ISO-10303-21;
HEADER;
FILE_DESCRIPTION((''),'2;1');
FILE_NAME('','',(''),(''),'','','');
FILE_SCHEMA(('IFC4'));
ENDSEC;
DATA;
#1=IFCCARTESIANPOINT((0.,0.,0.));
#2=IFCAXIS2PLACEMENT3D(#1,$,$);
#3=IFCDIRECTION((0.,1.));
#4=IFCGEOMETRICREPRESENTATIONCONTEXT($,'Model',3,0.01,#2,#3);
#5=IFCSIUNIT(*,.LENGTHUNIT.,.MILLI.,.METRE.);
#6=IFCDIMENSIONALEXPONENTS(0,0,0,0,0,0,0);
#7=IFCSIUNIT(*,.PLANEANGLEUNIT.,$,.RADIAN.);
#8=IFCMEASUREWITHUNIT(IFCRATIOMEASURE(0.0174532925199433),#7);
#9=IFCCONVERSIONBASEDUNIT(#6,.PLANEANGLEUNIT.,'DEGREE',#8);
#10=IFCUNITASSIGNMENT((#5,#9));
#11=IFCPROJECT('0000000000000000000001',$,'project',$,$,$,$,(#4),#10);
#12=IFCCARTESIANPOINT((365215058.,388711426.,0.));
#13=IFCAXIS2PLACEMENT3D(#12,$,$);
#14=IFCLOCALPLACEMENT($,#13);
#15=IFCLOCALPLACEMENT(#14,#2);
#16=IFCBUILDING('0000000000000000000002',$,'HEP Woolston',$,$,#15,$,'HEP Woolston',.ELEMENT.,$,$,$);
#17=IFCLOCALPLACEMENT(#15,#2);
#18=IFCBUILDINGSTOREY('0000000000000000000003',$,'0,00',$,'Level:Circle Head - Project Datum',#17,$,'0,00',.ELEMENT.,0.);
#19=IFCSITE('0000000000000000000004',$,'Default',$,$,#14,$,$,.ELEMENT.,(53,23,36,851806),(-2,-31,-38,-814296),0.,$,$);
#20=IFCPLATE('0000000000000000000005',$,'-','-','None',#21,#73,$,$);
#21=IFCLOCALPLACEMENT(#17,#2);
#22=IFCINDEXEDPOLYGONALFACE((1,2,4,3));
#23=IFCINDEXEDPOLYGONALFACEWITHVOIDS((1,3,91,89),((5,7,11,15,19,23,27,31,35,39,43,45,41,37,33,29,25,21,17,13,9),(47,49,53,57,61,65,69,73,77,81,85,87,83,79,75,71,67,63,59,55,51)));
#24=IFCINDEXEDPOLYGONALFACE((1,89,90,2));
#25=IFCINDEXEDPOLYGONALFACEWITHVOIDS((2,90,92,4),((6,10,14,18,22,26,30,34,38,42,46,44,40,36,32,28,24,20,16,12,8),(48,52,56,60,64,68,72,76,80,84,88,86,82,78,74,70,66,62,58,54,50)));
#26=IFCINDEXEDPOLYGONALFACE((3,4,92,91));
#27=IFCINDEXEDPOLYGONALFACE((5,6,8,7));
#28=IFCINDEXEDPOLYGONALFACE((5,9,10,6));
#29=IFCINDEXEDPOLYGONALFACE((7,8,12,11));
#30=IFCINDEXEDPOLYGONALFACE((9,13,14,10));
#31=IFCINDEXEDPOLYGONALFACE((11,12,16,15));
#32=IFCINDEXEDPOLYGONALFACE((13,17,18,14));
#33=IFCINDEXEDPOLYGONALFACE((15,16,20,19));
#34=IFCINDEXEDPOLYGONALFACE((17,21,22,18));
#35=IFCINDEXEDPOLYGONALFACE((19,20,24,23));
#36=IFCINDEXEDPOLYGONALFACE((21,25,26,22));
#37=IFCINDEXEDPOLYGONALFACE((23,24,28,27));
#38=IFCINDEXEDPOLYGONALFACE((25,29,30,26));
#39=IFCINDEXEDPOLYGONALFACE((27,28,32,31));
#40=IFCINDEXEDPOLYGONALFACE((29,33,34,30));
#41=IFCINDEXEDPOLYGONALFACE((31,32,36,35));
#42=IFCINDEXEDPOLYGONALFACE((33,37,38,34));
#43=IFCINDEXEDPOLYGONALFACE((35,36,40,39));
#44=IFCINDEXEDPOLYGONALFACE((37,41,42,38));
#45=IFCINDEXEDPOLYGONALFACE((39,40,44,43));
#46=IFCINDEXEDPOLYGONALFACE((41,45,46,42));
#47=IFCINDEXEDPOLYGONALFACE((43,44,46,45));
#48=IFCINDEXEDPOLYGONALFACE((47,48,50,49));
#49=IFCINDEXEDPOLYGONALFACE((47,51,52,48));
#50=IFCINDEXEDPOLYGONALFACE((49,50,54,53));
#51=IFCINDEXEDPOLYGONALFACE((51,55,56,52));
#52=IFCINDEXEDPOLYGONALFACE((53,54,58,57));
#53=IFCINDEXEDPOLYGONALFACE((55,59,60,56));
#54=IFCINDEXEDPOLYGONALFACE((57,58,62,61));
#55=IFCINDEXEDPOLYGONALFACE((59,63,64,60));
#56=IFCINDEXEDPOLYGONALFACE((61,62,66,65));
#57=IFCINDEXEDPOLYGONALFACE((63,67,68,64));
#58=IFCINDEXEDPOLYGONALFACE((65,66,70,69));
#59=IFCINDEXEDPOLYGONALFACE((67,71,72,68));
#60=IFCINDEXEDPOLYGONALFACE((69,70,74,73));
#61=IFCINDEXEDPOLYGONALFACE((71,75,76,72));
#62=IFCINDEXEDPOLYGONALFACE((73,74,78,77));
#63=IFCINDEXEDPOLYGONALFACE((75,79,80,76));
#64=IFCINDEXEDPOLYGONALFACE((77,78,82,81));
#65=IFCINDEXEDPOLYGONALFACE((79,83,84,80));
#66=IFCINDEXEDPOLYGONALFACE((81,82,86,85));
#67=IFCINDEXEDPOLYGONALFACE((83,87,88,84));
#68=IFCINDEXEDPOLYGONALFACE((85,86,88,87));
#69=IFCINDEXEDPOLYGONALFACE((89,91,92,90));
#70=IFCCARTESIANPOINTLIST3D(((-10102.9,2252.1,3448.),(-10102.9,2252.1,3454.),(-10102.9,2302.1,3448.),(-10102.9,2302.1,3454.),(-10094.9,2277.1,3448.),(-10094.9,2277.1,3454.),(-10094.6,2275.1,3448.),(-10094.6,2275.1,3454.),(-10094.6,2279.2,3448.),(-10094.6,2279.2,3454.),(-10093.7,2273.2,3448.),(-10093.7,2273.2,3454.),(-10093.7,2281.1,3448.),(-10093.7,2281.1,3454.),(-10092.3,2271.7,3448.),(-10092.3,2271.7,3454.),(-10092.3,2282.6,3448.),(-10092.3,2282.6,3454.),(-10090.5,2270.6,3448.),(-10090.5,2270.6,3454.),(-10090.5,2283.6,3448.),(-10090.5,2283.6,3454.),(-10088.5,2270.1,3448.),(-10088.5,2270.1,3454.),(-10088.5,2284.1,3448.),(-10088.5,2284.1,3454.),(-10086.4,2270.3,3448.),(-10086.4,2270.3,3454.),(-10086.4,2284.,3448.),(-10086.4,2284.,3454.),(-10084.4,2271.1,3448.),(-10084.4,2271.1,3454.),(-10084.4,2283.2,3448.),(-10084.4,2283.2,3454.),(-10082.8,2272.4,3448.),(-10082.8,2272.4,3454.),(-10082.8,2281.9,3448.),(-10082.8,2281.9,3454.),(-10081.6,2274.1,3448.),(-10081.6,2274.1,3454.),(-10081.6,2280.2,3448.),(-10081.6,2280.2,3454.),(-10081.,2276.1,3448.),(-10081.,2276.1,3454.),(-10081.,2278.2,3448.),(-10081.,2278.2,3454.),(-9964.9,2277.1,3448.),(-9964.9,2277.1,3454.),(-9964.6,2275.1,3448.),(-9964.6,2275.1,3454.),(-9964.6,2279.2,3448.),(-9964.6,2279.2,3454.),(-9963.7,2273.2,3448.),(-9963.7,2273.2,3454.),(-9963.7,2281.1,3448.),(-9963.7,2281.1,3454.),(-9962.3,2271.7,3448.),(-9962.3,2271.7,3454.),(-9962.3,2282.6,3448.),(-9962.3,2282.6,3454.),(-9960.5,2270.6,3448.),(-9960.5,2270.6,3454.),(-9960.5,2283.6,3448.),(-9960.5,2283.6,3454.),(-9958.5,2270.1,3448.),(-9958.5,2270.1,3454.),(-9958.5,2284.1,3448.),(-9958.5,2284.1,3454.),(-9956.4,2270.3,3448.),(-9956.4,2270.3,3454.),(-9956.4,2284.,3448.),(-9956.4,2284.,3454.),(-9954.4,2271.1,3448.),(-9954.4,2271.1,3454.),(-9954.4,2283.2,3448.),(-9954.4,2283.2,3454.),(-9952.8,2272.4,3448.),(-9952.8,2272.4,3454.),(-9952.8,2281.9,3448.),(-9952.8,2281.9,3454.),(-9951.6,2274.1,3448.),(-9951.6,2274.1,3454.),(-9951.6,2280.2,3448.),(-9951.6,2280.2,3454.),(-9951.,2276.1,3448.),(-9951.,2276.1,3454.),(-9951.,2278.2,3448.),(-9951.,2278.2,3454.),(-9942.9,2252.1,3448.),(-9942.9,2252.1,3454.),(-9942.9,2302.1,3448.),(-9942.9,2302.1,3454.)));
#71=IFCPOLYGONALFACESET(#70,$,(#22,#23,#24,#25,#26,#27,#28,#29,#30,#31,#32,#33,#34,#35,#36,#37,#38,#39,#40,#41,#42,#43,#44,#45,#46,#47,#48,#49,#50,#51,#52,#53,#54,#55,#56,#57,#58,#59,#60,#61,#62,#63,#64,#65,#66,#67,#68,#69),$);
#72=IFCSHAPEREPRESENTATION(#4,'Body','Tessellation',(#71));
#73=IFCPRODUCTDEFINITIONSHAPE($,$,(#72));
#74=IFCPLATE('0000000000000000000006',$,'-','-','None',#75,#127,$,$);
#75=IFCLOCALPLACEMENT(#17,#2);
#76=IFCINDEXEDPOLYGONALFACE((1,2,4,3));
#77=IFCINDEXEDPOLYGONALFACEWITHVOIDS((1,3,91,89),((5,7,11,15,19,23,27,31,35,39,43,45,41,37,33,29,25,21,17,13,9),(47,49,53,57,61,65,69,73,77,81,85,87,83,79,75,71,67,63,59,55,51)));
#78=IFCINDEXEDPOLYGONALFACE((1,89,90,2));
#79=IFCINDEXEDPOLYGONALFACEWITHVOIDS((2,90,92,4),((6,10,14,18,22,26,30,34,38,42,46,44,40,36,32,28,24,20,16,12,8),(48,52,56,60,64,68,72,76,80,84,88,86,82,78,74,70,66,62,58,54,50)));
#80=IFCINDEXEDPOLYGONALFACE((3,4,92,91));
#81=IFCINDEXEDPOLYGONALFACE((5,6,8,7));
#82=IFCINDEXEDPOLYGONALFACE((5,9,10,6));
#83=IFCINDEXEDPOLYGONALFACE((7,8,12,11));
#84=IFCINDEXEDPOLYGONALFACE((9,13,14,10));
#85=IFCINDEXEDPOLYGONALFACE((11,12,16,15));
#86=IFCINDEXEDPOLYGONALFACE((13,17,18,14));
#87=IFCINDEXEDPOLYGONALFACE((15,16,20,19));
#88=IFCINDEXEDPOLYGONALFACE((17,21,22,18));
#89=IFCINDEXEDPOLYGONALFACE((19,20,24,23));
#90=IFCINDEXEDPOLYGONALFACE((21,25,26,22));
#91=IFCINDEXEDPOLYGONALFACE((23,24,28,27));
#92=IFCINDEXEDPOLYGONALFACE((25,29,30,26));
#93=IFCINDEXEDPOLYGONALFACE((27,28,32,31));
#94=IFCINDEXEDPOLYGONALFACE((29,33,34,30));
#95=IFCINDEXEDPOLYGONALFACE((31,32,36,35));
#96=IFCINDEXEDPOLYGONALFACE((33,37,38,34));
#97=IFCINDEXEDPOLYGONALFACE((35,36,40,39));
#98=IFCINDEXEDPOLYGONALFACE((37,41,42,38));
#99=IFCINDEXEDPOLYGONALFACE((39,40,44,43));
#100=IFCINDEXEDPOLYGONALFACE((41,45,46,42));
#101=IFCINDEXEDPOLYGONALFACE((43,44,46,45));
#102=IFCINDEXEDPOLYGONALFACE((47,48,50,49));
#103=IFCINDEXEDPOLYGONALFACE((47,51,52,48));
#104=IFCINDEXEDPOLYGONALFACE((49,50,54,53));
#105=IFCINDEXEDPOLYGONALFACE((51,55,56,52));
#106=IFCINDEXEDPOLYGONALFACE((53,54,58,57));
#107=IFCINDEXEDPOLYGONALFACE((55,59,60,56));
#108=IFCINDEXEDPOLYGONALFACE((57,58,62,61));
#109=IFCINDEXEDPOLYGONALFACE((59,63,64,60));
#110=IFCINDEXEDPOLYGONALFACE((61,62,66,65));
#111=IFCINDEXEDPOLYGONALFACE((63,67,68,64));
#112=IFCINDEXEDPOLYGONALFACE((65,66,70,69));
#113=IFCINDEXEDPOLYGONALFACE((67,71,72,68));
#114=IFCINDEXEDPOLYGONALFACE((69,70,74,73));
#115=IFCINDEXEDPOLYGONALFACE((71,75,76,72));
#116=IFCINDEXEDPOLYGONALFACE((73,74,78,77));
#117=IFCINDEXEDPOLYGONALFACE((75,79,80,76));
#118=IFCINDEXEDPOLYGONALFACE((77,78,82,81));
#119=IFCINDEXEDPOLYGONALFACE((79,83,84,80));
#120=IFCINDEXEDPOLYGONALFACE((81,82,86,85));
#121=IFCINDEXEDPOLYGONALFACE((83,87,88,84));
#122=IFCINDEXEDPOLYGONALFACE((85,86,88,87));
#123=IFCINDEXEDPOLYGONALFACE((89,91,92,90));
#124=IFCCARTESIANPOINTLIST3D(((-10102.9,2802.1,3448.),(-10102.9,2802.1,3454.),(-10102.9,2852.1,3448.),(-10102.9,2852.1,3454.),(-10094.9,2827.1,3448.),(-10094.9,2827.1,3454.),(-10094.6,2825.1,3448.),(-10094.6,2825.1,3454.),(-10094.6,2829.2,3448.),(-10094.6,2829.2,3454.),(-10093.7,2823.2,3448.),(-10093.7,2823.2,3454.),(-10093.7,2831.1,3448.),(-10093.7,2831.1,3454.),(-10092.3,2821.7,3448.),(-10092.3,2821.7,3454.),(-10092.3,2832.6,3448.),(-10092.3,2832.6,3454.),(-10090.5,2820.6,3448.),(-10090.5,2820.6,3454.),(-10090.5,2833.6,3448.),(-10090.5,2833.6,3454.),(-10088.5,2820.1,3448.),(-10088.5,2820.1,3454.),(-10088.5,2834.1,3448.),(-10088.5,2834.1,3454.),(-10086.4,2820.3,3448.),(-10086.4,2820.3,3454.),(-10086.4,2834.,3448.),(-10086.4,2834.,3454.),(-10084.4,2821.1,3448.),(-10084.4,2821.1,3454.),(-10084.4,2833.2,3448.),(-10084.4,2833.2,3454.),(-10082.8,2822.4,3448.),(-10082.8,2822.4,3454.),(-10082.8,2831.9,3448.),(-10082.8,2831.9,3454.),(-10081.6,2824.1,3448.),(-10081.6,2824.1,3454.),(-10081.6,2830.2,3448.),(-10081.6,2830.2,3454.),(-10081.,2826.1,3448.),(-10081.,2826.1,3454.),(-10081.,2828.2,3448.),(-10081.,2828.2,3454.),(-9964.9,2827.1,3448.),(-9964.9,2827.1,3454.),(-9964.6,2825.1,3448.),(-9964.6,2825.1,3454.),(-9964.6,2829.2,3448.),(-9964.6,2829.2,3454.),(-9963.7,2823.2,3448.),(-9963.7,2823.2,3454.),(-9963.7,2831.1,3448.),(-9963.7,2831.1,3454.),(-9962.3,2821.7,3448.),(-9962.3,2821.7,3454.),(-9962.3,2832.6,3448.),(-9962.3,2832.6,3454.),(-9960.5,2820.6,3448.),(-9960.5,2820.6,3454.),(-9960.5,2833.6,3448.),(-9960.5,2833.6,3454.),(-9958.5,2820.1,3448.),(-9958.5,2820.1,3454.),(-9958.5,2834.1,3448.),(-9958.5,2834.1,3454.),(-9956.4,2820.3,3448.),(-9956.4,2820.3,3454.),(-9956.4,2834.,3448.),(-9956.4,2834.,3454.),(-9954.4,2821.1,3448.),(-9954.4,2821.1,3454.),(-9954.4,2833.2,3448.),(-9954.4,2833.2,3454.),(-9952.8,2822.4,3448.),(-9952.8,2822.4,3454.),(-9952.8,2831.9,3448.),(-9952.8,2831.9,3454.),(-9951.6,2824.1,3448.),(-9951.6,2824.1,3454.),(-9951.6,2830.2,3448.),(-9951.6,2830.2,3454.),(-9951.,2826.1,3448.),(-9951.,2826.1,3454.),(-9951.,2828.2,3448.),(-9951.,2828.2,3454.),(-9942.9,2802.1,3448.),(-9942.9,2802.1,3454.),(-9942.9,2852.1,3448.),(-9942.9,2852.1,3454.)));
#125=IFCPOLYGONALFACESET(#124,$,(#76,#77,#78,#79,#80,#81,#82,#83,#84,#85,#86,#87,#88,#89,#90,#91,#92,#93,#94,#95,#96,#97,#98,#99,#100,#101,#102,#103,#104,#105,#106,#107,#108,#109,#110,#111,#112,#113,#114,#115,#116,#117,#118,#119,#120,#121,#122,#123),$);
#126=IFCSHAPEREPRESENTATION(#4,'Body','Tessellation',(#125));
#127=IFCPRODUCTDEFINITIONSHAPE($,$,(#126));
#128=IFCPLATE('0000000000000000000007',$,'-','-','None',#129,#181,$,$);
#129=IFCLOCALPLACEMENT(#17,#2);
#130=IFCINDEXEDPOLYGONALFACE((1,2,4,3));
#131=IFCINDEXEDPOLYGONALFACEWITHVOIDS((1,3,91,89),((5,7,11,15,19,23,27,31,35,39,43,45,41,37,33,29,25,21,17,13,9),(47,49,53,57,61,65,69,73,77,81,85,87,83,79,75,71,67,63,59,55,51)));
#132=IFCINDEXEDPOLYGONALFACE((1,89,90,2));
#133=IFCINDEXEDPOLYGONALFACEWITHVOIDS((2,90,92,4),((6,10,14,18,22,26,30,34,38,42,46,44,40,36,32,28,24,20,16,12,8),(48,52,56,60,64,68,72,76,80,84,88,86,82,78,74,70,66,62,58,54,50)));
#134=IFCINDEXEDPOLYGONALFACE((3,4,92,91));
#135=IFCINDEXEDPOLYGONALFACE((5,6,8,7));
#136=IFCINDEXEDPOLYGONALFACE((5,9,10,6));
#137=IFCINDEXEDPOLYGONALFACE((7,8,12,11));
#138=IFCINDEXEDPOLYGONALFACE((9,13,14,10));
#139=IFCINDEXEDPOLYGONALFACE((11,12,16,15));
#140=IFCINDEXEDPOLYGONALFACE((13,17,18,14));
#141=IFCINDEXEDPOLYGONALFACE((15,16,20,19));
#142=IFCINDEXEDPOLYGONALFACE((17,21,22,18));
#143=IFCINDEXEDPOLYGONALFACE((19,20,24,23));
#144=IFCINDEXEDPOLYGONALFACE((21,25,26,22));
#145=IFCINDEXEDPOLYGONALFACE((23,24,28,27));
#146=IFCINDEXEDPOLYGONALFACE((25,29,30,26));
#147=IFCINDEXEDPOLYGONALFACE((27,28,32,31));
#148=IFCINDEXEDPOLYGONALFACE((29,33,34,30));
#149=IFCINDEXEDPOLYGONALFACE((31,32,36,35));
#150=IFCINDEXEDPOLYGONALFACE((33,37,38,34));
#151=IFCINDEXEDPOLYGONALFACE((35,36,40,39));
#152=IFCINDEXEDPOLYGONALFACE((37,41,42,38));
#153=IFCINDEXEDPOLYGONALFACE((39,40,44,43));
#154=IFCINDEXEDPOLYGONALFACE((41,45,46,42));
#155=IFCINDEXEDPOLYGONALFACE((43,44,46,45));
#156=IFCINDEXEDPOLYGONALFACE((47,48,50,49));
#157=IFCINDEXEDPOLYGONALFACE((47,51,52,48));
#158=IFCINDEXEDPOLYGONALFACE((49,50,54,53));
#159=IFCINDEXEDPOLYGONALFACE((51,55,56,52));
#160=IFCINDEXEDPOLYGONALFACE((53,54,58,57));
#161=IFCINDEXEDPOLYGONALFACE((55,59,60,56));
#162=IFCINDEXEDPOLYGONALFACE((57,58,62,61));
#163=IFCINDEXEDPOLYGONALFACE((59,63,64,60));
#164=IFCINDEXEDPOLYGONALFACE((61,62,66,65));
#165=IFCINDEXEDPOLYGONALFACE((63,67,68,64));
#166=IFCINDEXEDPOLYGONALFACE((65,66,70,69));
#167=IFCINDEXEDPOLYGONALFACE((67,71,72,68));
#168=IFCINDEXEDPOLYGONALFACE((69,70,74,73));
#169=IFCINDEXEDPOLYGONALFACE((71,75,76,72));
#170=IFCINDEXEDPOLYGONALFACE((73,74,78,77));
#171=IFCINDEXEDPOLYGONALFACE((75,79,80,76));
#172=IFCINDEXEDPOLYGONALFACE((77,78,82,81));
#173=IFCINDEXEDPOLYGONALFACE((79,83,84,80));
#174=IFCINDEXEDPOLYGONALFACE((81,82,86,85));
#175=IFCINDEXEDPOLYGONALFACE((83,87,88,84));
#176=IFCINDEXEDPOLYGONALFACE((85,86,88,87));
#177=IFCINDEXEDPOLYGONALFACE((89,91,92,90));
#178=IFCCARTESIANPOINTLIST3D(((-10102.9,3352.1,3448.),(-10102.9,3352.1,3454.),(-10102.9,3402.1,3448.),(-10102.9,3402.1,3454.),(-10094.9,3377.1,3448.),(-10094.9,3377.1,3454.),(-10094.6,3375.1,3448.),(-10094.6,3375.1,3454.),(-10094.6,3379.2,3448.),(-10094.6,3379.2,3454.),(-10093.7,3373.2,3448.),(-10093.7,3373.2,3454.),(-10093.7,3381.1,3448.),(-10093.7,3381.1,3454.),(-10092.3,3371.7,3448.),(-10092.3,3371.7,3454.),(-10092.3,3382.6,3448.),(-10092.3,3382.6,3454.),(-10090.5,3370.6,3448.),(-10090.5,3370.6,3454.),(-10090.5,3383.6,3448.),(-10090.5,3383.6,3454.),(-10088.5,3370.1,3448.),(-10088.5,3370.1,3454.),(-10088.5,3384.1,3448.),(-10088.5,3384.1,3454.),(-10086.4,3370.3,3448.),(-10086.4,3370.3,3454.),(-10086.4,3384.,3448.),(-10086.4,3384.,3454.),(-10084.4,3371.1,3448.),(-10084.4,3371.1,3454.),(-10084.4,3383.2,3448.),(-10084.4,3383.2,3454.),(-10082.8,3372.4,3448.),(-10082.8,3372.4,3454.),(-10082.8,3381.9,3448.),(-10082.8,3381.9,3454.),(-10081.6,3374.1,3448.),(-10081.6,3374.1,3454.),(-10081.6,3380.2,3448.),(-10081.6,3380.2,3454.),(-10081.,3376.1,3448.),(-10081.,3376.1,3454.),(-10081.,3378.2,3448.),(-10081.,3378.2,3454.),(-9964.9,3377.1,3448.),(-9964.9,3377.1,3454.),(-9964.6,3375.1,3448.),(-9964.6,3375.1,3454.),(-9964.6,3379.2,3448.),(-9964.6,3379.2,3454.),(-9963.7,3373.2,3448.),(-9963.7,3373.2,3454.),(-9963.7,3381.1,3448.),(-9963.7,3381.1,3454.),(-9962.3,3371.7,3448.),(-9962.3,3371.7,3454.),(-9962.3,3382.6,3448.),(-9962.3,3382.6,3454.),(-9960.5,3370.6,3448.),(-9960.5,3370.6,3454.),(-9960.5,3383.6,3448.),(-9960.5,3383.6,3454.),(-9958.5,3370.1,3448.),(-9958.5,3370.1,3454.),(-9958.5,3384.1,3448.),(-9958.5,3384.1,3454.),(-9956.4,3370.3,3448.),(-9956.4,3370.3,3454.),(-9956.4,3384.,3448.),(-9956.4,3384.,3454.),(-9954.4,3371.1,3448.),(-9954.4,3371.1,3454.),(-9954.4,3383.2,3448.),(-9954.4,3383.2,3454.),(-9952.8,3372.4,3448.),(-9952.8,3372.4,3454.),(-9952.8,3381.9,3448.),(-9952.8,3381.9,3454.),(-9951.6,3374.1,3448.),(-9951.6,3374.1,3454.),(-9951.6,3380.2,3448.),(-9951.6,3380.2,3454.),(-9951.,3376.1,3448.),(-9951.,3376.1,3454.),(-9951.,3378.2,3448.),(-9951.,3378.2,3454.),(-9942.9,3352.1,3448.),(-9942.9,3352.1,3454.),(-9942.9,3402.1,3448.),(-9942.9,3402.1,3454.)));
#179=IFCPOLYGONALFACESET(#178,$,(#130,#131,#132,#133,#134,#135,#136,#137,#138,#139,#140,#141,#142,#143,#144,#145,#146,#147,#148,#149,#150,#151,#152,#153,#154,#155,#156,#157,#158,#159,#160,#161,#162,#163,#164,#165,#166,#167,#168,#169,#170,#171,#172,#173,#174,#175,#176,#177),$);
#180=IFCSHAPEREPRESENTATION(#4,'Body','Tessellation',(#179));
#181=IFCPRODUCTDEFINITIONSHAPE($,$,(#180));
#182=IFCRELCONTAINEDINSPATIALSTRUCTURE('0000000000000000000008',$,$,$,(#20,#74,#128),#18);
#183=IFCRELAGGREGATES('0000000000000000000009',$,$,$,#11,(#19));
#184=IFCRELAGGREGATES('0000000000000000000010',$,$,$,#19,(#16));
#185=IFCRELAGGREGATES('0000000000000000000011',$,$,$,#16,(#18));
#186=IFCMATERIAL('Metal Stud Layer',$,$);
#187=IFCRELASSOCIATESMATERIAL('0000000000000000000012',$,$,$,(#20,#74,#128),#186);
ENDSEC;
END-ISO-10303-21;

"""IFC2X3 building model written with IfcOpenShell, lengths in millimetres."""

from ifc_helpers import new_model, entity, si_unit, converted_unit, direction, frame, frame_2d, origin, origin_with_axes, place, context, project, spatial, polyline, circle, outline, extrude, material, element, save


model = new_model("IFC2X3")

# Units and contexts
model_context = context("Model", 3, precision=0.01, world=origin(), true_north=direction((0.0, 1.0)))
ifc_project = project(units=[si_unit("LENGTHUNIT", "METRE", prefix="MILLI"), converted_unit("PLANEANGLEUNIT", "DEGREE", entity("IfcRatioMeasure", 0.0174532925199433), si_unit("PLANEANGLEUNIT", "RADIAN"), dimensions=[0, 0, 0, 0, 0, 0, 0])], contexts=[model_context])

# Site, building, storey
site_placement = place(None, frame((365215058.0, 388711426.0, 0.0)))
site = spatial("IfcSite", under=ifc_project, at=site_placement, Name="Default", CompositionType="ELEMENT", RefLatitude=(53, 23, 36, 851806), RefLongitude=(-2, -31, -38, -814296), RefElevation=0.0)
building_placement = place(site_placement, origin())
building = spatial("IfcBuilding", under=site, at=building_placement, Name="HEP Woolston", LongName="HEP Woolston", CompositionType="ELEMENT")
storey_placement = place(building_placement, origin())
storey = spatial("IfcBuildingStorey", under=building, at=storey_placement, Name="0,00", ObjectType="Level:Circle Head - Project Datum", LongName="0,00", CompositionType="ELEMENT", Elevation=0.0)

# Plates, openings
ifc_material = material(Name="Metal Stud Layer")
plate_1_placement = place(storey_placement, frame((-9942.9, 2252.1, 3454.0), z_axis=(0.0, 0.0, -1.0), x_axis=(-1.0, 0.0, 0.0)))
plate_1 = element("IfcPlate", 1, at=plate_1_placement, inside=storey, material=ifc_material, Name="-", Description="-", ObjectType="None", context=model_context, shape_type="SweptSolid", body=[
    extrude(outline(polyline([(160.0, 0.0), (160.0, 50.0), (0.0, 50.0), (0.0, 0.0), (160.0, 0.0)])), origin_with_axes(), (0.0, 0.0, 1.0), 6.0),
])
opening_1_placement = place(plate_1_placement, frame((80.0, 25.0, 6.5), z_axis=(0.0, 0.0, -1.0), x_axis=(1.0, 0.0, 0.0)))
element("IfcOpeningElement", 2, at=opening_1_placement, cuts=plate_1, ObjectType="Opening", context=model_context, shape_type="SweptSolid", body=[
    extrude(circle(Radius=7.0, at=frame_2d((65.0, 0.0), x_axis=(1.0, 0.0))), origin(), (0.0, 0.0, 1.0), 7.0),
])
opening_2_placement = place(plate_1_placement, frame((80.0, 25.0, 6.5), z_axis=(0.0, 0.0, -1.0), x_axis=(1.0, 0.0, 0.0)))
element("IfcOpeningElement", 3, at=opening_2_placement, cuts=plate_1, ObjectType="Opening", context=model_context, shape_type="SweptSolid", body=[
    extrude(circle(Radius=7.0, at=frame_2d((-65.0, 0.0), x_axis=(1.0, 0.0))), origin(), (0.0, 0.0, 1.0), 7.0),
])
plate_2_placement = place(storey_placement, frame((-9942.9, 2802.1, 3454.0), z_axis=(0.0, 0.0, -1.0), x_axis=(-1.0, 0.0, 0.0)))
plate_2 = element("IfcPlate", 4, at=plate_2_placement, inside=storey, material=ifc_material, Name="-", Description="-", ObjectType="None", context=model_context, shape_type="SweptSolid", body=[
    extrude(outline(polyline([(160.0, 0.0), (160.0, 50.0), (0.0, 50.0), (0.0, 0.0), (160.0, 0.0)])), origin_with_axes(), (0.0, 0.0, 1.0), 6.0),
])
opening_3_placement = place(plate_2_placement, frame((80.0, 25.0, 6.5), z_axis=(0.0, 0.0, -1.0), x_axis=(1.0, 0.0, 0.0)))
element("IfcOpeningElement", 5, at=opening_3_placement, cuts=plate_2, ObjectType="Opening", context=model_context, shape_type="SweptSolid", body=[
    extrude(circle(Radius=7.0, at=frame_2d((65.0, 0.0), x_axis=(1.0, 0.0))), origin(), (0.0, 0.0, 1.0), 7.0),
])
opening_4_placement = place(plate_2_placement, frame((80.0, 25.0, 6.5), z_axis=(0.0, 0.0, -1.0), x_axis=(1.0, 0.0, 0.0)))
element("IfcOpeningElement", 6, at=opening_4_placement, cuts=plate_2, ObjectType="Opening", context=model_context, shape_type="SweptSolid", body=[
    extrude(circle(Radius=7.0, at=frame_2d((-65.0, 0.0), x_axis=(1.0, 0.0))), origin(), (0.0, 0.0, 1.0), 7.0),
])
plate_3_placement = place(storey_placement, frame((-9942.9, 3352.1, 3454.0), z_axis=(0.0, 0.0, -1.0), x_axis=(-1.0, 0.0, 0.0)))
plate_3 = element("IfcPlate", 7, at=plate_3_placement, inside=storey, material=ifc_material, Name="-", Description="-", ObjectType="None", context=model_context, shape_type="SweptSolid", body=[
    extrude(outline(polyline([(160.0, 0.0), (160.0, 50.0), (0.0, 50.0), (0.0, 0.0), (160.0, 0.0)])), origin_with_axes(), (0.0, 0.0, 1.0), 6.0),
])
opening_5_placement = place(plate_3_placement, frame((80.0, 25.0, 6.5), z_axis=(0.0, 0.0, -1.0), x_axis=(1.0, 0.0, 0.0)))
element("IfcOpeningElement", 8, at=opening_5_placement, cuts=plate_3, ObjectType="Opening", context=model_context, shape_type="SweptSolid", body=[
    extrude(circle(Radius=7.0, at=frame_2d((65.0, 0.0), x_axis=(1.0, 0.0))), origin(), (0.0, 0.0, 1.0), 7.0),
])
opening_6_placement = place(plate_3_placement, frame((80.0, 25.0, 6.5), z_axis=(0.0, 0.0, -1.0), x_axis=(1.0, 0.0, 0.0)))
element("IfcOpeningElement", 9, at=opening_6_placement, cuts=plate_3, ObjectType="Opening", context=model_context, shape_type="SweptSolid", body=[
    extrude(circle(Radius=7.0, at=frame_2d((-65.0, 0.0), x_axis=(1.0, 0.0))), origin(), (0.0, 0.0, 1.0), 7.0),
])

save(model, "model.ifc")
